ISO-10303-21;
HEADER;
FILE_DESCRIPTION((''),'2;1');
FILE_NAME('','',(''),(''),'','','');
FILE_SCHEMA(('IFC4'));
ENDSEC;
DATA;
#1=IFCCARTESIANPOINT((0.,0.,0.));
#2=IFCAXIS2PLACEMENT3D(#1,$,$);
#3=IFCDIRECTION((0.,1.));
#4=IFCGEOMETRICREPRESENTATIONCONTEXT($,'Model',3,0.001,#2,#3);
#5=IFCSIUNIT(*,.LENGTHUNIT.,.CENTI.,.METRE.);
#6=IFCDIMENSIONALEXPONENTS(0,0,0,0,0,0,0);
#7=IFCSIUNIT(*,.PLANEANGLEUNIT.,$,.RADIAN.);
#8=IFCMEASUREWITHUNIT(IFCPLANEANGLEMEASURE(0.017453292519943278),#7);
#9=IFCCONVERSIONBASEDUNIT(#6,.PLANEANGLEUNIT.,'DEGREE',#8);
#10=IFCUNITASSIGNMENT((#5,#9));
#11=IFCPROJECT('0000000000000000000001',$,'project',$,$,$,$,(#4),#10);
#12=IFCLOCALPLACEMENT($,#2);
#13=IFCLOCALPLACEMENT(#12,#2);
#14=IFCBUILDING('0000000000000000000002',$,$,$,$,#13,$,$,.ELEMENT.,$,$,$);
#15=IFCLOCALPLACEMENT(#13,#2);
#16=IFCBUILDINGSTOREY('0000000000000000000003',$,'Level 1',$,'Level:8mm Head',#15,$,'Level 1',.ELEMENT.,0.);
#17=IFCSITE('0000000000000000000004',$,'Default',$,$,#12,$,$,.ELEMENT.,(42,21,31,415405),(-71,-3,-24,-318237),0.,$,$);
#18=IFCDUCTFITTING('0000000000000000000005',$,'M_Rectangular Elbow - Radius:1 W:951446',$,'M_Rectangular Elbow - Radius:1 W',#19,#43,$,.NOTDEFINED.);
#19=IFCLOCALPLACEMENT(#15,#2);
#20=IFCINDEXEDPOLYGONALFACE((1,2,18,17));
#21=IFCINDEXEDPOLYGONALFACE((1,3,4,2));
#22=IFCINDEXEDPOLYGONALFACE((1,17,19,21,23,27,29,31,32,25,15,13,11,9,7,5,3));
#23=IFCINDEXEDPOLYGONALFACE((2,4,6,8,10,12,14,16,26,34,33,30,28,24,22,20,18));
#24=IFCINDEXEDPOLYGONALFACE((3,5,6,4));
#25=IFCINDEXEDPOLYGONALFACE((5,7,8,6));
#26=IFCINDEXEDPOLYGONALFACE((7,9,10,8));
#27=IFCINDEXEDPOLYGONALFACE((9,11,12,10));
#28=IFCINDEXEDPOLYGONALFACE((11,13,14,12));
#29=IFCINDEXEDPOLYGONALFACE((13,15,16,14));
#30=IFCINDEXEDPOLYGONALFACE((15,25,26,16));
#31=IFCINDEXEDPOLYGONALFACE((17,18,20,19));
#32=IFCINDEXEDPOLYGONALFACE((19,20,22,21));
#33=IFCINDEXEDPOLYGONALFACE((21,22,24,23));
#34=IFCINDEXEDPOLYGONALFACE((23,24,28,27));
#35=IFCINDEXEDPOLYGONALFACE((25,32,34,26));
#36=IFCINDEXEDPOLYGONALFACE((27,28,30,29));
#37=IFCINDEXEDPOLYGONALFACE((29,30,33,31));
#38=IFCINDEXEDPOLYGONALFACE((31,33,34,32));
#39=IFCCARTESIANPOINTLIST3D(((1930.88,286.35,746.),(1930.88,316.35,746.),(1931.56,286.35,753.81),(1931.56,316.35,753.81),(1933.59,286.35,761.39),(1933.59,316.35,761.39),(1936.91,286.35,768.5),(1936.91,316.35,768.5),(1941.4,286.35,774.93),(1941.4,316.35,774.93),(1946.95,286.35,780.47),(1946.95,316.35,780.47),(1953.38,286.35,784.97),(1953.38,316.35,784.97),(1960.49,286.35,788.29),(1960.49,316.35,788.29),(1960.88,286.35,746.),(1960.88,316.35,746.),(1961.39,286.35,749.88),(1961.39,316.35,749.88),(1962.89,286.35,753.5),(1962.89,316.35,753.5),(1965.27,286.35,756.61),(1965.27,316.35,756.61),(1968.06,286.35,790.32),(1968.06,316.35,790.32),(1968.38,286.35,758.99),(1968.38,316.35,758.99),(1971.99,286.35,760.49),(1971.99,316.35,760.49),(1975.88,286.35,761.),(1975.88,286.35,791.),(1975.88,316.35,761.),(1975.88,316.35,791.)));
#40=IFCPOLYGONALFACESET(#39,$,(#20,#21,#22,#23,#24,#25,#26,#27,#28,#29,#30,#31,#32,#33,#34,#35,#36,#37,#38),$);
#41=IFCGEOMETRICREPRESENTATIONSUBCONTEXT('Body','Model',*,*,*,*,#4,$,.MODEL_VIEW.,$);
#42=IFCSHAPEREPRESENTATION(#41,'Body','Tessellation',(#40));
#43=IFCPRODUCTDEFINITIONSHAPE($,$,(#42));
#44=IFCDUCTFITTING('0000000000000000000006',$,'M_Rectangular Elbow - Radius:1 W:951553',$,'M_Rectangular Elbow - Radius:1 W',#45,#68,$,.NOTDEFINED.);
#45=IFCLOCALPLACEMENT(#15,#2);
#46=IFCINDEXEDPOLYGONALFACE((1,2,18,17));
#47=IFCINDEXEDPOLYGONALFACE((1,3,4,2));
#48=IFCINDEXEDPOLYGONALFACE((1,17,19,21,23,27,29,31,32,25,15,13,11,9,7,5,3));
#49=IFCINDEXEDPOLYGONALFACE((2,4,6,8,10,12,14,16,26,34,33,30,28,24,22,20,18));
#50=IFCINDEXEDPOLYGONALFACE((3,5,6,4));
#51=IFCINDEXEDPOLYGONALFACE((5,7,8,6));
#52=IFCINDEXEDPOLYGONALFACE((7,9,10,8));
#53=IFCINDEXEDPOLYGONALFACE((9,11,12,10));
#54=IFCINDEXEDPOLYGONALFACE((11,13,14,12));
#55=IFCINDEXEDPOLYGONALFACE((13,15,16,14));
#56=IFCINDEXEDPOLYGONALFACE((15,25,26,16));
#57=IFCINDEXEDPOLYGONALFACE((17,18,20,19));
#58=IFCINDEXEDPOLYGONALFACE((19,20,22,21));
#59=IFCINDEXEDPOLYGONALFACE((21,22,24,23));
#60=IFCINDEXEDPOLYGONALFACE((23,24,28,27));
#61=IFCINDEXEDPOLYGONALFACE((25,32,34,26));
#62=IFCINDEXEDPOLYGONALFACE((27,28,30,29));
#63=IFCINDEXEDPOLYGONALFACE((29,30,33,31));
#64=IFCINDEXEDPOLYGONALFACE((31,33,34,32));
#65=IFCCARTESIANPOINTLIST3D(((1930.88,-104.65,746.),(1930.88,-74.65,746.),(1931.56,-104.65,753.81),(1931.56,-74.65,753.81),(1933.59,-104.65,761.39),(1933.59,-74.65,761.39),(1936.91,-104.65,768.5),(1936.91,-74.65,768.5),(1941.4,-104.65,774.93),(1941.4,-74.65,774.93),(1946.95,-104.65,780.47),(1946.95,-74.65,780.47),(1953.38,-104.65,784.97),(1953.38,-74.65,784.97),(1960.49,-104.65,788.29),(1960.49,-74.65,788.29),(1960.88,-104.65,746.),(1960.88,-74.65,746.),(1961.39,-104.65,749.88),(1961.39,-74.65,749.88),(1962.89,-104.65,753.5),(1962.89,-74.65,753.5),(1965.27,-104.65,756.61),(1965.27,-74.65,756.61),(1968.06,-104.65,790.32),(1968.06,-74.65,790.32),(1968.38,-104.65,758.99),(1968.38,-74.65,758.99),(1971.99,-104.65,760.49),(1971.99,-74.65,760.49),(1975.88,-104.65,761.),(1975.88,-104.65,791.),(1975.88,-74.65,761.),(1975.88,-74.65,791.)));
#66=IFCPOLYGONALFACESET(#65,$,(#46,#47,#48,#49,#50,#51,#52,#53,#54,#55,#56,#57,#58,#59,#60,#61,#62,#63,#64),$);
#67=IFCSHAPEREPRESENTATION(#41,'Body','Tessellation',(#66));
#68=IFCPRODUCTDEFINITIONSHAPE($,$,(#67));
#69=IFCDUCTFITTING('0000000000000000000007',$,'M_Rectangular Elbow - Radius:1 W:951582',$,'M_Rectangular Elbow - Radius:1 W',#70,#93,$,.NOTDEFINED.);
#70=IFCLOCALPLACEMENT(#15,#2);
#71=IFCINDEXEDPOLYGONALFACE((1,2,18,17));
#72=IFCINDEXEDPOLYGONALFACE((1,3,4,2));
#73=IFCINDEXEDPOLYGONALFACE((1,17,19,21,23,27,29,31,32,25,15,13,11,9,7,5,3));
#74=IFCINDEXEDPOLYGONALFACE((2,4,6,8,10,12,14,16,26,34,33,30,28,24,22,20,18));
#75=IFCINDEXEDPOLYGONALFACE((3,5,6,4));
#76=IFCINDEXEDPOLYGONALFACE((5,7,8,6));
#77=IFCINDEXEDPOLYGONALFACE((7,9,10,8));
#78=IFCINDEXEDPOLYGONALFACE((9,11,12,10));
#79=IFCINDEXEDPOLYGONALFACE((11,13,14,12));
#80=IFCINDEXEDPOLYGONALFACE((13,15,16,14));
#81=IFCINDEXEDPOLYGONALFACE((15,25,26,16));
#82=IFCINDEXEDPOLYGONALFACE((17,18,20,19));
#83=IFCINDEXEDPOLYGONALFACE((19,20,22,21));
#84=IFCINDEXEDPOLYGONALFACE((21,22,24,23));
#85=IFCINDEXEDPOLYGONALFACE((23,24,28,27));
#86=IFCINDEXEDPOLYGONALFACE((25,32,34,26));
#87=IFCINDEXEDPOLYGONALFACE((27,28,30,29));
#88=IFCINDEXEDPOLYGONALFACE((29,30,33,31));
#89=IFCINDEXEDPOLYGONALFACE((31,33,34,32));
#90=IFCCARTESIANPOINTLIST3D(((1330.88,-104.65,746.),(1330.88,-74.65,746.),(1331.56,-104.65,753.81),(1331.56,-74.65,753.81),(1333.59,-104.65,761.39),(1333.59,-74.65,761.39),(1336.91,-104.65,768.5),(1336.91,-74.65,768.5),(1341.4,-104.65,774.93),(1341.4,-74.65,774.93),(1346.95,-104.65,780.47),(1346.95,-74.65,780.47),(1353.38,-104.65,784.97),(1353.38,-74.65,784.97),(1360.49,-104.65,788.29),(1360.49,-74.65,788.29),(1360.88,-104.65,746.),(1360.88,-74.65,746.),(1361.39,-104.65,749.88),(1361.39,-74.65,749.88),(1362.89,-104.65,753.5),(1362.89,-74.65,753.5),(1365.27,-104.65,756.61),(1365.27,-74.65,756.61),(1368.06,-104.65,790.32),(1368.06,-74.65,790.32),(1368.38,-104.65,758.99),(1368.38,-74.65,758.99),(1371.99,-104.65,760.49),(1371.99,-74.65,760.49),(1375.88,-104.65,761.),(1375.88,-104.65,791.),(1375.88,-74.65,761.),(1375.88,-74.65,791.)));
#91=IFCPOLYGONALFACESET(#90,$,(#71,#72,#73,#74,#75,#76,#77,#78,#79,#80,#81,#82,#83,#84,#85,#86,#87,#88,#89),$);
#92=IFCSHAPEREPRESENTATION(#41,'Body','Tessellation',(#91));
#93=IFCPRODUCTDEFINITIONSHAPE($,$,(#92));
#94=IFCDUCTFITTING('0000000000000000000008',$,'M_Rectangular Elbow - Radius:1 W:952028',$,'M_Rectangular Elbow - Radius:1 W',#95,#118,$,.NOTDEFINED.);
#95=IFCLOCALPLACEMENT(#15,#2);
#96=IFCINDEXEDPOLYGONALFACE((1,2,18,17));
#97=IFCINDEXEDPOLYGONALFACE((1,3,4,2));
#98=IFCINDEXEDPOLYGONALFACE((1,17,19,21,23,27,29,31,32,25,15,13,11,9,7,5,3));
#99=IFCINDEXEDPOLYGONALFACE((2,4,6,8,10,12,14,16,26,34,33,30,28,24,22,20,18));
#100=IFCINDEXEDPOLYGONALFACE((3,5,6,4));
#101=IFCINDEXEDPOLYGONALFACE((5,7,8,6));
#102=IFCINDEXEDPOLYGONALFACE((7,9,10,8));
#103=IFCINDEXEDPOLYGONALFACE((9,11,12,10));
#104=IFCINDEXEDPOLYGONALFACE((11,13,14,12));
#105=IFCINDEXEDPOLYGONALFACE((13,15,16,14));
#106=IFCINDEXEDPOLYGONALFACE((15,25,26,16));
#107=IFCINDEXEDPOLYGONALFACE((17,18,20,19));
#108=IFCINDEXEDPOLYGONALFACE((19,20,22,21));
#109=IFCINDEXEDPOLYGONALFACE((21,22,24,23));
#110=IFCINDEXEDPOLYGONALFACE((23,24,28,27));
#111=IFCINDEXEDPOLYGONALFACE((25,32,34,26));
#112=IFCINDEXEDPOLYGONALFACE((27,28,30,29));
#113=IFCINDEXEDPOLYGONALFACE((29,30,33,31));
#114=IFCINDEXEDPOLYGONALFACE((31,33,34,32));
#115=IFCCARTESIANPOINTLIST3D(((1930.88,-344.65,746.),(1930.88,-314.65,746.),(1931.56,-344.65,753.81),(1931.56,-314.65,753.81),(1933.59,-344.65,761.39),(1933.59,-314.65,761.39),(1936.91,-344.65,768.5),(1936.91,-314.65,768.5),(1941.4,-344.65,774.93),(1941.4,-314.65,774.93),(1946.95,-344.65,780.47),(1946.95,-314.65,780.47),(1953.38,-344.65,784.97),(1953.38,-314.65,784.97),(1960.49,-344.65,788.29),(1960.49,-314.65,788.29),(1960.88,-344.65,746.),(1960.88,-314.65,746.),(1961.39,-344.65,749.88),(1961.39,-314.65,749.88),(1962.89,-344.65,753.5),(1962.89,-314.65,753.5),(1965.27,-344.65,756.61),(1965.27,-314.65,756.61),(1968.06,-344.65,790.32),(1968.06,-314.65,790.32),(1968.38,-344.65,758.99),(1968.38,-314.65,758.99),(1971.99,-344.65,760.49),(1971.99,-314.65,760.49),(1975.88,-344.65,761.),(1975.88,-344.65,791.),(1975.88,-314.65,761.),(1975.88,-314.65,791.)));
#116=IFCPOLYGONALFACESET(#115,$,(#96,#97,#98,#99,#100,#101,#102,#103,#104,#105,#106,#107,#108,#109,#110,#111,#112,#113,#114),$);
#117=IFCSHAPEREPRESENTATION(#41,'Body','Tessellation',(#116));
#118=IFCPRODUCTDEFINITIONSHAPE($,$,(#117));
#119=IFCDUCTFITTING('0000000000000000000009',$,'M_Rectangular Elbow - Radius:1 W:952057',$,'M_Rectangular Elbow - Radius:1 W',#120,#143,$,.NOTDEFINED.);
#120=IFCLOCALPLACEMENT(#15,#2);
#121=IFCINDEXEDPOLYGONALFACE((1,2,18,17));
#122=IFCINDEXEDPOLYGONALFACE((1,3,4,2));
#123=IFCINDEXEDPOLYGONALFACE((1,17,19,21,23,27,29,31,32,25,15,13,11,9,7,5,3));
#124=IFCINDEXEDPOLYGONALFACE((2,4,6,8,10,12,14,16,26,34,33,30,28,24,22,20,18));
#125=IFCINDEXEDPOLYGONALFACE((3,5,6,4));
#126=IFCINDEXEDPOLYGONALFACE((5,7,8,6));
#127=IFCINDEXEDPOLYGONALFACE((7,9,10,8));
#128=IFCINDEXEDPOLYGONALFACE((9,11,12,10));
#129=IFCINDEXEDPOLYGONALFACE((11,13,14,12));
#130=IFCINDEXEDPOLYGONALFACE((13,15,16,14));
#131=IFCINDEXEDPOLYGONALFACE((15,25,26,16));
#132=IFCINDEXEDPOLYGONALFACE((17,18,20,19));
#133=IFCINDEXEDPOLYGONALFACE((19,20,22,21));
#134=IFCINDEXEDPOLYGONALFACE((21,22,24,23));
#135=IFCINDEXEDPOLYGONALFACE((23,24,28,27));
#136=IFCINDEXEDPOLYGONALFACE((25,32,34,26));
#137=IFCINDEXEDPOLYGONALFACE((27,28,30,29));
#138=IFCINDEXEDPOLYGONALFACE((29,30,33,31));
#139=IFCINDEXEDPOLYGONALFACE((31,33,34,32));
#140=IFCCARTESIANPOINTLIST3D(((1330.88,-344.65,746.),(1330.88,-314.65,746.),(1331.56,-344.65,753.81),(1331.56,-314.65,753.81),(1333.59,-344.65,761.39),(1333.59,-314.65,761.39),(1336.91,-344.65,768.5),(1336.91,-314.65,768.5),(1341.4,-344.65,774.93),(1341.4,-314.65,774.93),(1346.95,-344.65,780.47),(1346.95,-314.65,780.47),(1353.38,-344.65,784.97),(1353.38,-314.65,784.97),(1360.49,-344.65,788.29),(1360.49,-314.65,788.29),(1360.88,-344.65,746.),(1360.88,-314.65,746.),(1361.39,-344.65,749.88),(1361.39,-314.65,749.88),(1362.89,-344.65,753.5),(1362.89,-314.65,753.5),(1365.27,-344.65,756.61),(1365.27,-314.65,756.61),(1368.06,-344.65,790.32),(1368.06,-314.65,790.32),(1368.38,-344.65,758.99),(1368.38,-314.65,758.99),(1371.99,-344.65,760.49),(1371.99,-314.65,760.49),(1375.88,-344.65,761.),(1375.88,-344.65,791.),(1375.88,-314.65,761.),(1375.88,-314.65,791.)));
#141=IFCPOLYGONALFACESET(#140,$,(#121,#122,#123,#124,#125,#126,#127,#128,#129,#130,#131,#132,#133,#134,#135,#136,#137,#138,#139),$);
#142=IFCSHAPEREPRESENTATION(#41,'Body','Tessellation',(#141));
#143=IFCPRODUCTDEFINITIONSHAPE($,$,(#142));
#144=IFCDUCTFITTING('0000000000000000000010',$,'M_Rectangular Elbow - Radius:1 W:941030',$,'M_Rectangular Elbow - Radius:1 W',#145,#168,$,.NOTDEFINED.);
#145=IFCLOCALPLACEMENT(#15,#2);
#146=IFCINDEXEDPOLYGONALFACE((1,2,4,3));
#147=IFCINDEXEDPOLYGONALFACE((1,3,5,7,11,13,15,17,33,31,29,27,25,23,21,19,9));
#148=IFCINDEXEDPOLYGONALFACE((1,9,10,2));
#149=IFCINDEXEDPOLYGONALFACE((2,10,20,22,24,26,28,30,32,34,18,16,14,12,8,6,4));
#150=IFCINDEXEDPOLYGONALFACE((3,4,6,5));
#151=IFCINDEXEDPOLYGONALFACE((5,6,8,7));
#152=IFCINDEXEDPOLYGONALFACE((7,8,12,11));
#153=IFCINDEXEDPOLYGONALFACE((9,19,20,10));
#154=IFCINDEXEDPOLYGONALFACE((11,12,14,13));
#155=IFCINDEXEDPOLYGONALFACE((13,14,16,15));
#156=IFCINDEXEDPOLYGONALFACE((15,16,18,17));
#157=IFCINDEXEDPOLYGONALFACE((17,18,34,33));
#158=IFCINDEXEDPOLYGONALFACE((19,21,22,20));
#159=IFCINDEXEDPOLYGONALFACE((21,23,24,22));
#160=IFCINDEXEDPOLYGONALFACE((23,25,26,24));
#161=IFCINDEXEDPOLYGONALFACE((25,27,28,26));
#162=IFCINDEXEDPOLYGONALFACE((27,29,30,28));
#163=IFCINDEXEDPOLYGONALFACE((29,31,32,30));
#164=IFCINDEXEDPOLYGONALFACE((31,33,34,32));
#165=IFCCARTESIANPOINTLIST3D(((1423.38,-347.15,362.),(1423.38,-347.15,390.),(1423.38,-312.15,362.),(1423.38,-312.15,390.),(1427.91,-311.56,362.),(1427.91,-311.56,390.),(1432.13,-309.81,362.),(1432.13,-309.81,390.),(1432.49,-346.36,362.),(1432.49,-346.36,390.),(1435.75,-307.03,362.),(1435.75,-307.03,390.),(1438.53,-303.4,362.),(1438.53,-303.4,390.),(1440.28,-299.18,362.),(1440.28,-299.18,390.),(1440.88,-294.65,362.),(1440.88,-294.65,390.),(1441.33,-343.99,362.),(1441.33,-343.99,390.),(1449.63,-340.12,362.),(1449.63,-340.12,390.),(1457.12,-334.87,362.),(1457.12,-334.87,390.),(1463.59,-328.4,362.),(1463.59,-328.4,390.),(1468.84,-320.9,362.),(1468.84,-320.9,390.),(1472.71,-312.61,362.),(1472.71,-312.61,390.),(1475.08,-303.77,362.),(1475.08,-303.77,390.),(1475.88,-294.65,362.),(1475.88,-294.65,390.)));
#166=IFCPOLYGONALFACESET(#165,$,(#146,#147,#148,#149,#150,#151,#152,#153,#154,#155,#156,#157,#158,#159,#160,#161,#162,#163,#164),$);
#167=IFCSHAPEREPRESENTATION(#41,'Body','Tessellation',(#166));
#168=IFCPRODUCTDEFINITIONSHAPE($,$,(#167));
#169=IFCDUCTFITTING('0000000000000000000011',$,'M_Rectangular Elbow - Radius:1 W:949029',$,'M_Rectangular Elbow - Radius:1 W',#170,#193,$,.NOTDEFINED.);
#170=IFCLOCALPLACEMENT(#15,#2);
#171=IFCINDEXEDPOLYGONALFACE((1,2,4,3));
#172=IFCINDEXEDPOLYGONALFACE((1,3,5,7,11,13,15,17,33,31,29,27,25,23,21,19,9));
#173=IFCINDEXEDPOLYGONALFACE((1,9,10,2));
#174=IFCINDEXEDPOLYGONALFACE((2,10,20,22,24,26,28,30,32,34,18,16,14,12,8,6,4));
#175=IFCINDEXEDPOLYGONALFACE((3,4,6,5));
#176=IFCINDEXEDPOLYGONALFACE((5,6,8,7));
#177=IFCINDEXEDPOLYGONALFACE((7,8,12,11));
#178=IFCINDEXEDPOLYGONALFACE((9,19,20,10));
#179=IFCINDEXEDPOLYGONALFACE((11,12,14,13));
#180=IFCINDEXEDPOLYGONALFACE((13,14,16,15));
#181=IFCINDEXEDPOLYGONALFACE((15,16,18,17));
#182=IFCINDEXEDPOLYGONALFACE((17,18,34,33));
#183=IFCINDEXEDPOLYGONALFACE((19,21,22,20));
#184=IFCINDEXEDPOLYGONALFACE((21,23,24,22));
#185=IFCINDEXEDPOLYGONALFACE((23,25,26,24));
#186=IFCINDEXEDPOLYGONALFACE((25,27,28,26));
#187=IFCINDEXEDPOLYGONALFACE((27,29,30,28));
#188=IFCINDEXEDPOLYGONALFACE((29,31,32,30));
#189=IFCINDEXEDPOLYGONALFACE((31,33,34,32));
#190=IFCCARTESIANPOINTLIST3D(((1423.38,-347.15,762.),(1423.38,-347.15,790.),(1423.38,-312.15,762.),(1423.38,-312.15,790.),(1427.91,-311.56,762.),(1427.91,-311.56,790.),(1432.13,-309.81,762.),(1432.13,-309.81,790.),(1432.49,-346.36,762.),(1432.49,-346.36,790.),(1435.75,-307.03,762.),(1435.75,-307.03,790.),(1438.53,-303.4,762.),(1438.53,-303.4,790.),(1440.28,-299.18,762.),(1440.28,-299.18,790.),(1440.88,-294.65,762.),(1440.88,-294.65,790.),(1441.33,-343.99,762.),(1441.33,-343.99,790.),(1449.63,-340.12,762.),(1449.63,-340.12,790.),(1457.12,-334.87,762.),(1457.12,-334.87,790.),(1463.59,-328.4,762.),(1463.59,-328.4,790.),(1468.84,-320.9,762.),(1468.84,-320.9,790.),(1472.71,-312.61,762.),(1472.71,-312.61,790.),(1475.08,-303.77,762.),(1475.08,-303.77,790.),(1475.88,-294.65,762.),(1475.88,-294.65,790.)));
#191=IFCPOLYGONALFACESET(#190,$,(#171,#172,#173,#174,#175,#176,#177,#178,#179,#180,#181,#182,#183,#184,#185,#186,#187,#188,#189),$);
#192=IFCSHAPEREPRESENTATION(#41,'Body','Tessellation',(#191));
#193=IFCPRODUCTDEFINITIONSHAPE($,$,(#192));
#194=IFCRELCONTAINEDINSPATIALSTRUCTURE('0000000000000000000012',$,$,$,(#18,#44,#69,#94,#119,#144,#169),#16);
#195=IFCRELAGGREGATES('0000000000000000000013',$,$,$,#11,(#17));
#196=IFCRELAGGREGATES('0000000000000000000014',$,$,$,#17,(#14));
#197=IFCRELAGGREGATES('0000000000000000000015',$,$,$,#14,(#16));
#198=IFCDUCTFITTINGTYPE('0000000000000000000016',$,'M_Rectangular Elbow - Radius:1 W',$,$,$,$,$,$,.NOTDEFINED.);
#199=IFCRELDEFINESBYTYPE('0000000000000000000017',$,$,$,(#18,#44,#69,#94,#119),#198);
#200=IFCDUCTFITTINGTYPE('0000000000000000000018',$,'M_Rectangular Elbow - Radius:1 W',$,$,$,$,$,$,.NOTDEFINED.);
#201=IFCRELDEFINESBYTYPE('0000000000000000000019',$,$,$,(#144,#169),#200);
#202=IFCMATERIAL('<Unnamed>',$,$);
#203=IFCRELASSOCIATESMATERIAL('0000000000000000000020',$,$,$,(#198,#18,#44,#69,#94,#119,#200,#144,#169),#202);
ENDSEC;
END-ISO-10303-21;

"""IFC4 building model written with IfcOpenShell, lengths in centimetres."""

from ifc_helpers import new_model, entity, si_unit, converted_unit, direction, frame, origin, place, context, subcontext, project, spatial, line, arc, indexed_curve, outline, extrude, source, transform, mapped, material, type_object, type_shapes, element, save


model = new_model("IFC4")

# Units and contexts
model_context = context("Model", 3, precision=0.001, world=origin(), true_north=direction((0.0, 1.0)))
body_context = subcontext(model_context, "Body", "Model", "MODEL_VIEW")
ifc_project = project(units=[si_unit("LENGTHUNIT", "METRE", prefix="CENTI"), converted_unit("PLANEANGLEUNIT", "DEGREE", entity("IfcPlaneAngleMeasure", 0.017453292519943278), si_unit("PLANEANGLEUNIT", "RADIAN"), dimensions=[0, 0, 0, 0, 0, 0, 0])], contexts=[model_context])

# Site, building, storey
site_placement = place(None, origin())
site = spatial("IfcSite", under=ifc_project, at=site_placement, Name="Default", CompositionType="ELEMENT", RefLatitude=(42, 21, 31, 415405), RefLongitude=(-71, -3, -24, -318237), RefElevation=0.0)
building_placement = place(site_placement, origin())
building = spatial("IfcBuilding", under=site, at=building_placement, CompositionType="ELEMENT")
storey_placement = place(building_placement, origin())
storey = spatial("IfcBuildingStorey", under=building, at=storey_placement, Name="Level 1", ObjectType="Level:8mm Head", LongName="Level 1", CompositionType="ELEMENT", Elevation=0.0)

# Duct fittings
ifc_material = material(Name="<Unnamed>")
duct_fitting_type_1 = type_object("IfcDuctFittingType", Name="M_Rectangular Elbow - Radius:1 W", PredefinedType="NOTDEFINED", material=ifc_material)
shared_shape_1 = source(origin(), body_context, "Body", "SweptSolid", [
    extrude(outline(indexed_curve([(-30.0, -15.0), (0.0, -15.0), (4.39, -4.39), (15.0, 0.0), (15.0, 30.0), (-16.82, 16.82)], segments=[line(1, 2), arc(2, 3, 4), line(4, 5), arc(5, 6, 1)], self_intersect=False)), frame((-15.0, 15.0, -15.0), z_axis=(0.0, 0.0, 1.0), x_axis=(-1.0, 0.0, 0.0)), (0.0, 0.0, 1.0), 30.0),
])
type_shapes(duct_fitting_type_1, [shared_shape_1])
for number, where, z_axis, x_axis, name in (
    (1, (1945.88, 301.35, 776.0), (0.0, -1.0, 0.0), (-1.0, 0.0, 0.0), "M_Rectangular Elbow - Radius:1 W:951446"),
    (2, (1945.88, -89.65, 776.0), (0.0, -1.0, 0.0), (-1.0, 0.0, 0.0), "M_Rectangular Elbow - Radius:1 W:951553"),
    (3, (1345.88, -89.65, 776.0), (0.0, -1.0, 0.0), (-1.0, 0.0, 0.0), "M_Rectangular Elbow - Radius:1 W:951582"),
    (4, (1945.88, -329.65, 776.0), (0.0, -1.0, 0.0), (-1.0, 0.0, 0.0), "M_Rectangular Elbow - Radius:1 W:952028"),
    (5, (1345.88, -329.65, 776.0), (0.0, -1.0, 0.0), (-1.0, 0.0, 0.0), "M_Rectangular Elbow - Radius:1 W:952057"),
):
    element("IfcDuctFitting", number, at=place(storey_placement, frame(where, z_axis=z_axis, x_axis=x_axis)), inside=storey, type_object=duct_fitting_type_1, material=ifc_material, Name=name, ObjectType="M_Rectangular Elbow - Radius:1 W", PredefinedType="NOTDEFINED", context=body_context, shape_type="MappedRepresentation", body=[
        mapped(shared_shape_1, transform((0.0, 0.0, 0.0), scale=1.0)),
    ])
duct_fitting_type_2 = type_object("IfcDuctFittingType", Name="M_Rectangular Elbow - Radius:1 W", PredefinedType="NOTDEFINED", material=ifc_material)
shared_shape_2 = source(origin(), body_context, "Body", "SweptSolid", [
    extrude(outline(indexed_curve([(-35.0, -17.5), (0.0, -17.5), (5.13, -5.13), (17.5, 0.0), (17.5, 35.0), (-19.62, 19.62)], segments=[line(1, 2), arc(2, 3, 4), line(4, 5), arc(5, 6, 1)], self_intersect=False)), frame((-17.5, 17.5, -14.0), z_axis=(0.0, 0.0, 1.0), x_axis=(-1.0, 0.0, 0.0)), (0.0, 0.0, 1.0), 28.0),
])
type_shapes(duct_fitting_type_2, [shared_shape_2])
for number, where, name in (
    (6, (1458.38, -329.65, 376.0), "M_Rectangular Elbow - Radius:1 W:941030"),
    (7, (1458.38, -329.65, 776.0), "M_Rectangular Elbow - Radius:1 W:949029"),
):
    element("IfcDuctFitting", number, at=place(storey_placement, frame(where)), inside=storey, type_object=duct_fitting_type_2, material=ifc_material, Name=name, ObjectType="M_Rectangular Elbow - Radius:1 W", PredefinedType="NOTDEFINED", context=body_context, shape_type="MappedRepresentation", body=[
        mapped(shared_shape_2, transform((0.0, 0.0, 0.0), scale=1.0)),
    ])

save(model, "model.ifc")
